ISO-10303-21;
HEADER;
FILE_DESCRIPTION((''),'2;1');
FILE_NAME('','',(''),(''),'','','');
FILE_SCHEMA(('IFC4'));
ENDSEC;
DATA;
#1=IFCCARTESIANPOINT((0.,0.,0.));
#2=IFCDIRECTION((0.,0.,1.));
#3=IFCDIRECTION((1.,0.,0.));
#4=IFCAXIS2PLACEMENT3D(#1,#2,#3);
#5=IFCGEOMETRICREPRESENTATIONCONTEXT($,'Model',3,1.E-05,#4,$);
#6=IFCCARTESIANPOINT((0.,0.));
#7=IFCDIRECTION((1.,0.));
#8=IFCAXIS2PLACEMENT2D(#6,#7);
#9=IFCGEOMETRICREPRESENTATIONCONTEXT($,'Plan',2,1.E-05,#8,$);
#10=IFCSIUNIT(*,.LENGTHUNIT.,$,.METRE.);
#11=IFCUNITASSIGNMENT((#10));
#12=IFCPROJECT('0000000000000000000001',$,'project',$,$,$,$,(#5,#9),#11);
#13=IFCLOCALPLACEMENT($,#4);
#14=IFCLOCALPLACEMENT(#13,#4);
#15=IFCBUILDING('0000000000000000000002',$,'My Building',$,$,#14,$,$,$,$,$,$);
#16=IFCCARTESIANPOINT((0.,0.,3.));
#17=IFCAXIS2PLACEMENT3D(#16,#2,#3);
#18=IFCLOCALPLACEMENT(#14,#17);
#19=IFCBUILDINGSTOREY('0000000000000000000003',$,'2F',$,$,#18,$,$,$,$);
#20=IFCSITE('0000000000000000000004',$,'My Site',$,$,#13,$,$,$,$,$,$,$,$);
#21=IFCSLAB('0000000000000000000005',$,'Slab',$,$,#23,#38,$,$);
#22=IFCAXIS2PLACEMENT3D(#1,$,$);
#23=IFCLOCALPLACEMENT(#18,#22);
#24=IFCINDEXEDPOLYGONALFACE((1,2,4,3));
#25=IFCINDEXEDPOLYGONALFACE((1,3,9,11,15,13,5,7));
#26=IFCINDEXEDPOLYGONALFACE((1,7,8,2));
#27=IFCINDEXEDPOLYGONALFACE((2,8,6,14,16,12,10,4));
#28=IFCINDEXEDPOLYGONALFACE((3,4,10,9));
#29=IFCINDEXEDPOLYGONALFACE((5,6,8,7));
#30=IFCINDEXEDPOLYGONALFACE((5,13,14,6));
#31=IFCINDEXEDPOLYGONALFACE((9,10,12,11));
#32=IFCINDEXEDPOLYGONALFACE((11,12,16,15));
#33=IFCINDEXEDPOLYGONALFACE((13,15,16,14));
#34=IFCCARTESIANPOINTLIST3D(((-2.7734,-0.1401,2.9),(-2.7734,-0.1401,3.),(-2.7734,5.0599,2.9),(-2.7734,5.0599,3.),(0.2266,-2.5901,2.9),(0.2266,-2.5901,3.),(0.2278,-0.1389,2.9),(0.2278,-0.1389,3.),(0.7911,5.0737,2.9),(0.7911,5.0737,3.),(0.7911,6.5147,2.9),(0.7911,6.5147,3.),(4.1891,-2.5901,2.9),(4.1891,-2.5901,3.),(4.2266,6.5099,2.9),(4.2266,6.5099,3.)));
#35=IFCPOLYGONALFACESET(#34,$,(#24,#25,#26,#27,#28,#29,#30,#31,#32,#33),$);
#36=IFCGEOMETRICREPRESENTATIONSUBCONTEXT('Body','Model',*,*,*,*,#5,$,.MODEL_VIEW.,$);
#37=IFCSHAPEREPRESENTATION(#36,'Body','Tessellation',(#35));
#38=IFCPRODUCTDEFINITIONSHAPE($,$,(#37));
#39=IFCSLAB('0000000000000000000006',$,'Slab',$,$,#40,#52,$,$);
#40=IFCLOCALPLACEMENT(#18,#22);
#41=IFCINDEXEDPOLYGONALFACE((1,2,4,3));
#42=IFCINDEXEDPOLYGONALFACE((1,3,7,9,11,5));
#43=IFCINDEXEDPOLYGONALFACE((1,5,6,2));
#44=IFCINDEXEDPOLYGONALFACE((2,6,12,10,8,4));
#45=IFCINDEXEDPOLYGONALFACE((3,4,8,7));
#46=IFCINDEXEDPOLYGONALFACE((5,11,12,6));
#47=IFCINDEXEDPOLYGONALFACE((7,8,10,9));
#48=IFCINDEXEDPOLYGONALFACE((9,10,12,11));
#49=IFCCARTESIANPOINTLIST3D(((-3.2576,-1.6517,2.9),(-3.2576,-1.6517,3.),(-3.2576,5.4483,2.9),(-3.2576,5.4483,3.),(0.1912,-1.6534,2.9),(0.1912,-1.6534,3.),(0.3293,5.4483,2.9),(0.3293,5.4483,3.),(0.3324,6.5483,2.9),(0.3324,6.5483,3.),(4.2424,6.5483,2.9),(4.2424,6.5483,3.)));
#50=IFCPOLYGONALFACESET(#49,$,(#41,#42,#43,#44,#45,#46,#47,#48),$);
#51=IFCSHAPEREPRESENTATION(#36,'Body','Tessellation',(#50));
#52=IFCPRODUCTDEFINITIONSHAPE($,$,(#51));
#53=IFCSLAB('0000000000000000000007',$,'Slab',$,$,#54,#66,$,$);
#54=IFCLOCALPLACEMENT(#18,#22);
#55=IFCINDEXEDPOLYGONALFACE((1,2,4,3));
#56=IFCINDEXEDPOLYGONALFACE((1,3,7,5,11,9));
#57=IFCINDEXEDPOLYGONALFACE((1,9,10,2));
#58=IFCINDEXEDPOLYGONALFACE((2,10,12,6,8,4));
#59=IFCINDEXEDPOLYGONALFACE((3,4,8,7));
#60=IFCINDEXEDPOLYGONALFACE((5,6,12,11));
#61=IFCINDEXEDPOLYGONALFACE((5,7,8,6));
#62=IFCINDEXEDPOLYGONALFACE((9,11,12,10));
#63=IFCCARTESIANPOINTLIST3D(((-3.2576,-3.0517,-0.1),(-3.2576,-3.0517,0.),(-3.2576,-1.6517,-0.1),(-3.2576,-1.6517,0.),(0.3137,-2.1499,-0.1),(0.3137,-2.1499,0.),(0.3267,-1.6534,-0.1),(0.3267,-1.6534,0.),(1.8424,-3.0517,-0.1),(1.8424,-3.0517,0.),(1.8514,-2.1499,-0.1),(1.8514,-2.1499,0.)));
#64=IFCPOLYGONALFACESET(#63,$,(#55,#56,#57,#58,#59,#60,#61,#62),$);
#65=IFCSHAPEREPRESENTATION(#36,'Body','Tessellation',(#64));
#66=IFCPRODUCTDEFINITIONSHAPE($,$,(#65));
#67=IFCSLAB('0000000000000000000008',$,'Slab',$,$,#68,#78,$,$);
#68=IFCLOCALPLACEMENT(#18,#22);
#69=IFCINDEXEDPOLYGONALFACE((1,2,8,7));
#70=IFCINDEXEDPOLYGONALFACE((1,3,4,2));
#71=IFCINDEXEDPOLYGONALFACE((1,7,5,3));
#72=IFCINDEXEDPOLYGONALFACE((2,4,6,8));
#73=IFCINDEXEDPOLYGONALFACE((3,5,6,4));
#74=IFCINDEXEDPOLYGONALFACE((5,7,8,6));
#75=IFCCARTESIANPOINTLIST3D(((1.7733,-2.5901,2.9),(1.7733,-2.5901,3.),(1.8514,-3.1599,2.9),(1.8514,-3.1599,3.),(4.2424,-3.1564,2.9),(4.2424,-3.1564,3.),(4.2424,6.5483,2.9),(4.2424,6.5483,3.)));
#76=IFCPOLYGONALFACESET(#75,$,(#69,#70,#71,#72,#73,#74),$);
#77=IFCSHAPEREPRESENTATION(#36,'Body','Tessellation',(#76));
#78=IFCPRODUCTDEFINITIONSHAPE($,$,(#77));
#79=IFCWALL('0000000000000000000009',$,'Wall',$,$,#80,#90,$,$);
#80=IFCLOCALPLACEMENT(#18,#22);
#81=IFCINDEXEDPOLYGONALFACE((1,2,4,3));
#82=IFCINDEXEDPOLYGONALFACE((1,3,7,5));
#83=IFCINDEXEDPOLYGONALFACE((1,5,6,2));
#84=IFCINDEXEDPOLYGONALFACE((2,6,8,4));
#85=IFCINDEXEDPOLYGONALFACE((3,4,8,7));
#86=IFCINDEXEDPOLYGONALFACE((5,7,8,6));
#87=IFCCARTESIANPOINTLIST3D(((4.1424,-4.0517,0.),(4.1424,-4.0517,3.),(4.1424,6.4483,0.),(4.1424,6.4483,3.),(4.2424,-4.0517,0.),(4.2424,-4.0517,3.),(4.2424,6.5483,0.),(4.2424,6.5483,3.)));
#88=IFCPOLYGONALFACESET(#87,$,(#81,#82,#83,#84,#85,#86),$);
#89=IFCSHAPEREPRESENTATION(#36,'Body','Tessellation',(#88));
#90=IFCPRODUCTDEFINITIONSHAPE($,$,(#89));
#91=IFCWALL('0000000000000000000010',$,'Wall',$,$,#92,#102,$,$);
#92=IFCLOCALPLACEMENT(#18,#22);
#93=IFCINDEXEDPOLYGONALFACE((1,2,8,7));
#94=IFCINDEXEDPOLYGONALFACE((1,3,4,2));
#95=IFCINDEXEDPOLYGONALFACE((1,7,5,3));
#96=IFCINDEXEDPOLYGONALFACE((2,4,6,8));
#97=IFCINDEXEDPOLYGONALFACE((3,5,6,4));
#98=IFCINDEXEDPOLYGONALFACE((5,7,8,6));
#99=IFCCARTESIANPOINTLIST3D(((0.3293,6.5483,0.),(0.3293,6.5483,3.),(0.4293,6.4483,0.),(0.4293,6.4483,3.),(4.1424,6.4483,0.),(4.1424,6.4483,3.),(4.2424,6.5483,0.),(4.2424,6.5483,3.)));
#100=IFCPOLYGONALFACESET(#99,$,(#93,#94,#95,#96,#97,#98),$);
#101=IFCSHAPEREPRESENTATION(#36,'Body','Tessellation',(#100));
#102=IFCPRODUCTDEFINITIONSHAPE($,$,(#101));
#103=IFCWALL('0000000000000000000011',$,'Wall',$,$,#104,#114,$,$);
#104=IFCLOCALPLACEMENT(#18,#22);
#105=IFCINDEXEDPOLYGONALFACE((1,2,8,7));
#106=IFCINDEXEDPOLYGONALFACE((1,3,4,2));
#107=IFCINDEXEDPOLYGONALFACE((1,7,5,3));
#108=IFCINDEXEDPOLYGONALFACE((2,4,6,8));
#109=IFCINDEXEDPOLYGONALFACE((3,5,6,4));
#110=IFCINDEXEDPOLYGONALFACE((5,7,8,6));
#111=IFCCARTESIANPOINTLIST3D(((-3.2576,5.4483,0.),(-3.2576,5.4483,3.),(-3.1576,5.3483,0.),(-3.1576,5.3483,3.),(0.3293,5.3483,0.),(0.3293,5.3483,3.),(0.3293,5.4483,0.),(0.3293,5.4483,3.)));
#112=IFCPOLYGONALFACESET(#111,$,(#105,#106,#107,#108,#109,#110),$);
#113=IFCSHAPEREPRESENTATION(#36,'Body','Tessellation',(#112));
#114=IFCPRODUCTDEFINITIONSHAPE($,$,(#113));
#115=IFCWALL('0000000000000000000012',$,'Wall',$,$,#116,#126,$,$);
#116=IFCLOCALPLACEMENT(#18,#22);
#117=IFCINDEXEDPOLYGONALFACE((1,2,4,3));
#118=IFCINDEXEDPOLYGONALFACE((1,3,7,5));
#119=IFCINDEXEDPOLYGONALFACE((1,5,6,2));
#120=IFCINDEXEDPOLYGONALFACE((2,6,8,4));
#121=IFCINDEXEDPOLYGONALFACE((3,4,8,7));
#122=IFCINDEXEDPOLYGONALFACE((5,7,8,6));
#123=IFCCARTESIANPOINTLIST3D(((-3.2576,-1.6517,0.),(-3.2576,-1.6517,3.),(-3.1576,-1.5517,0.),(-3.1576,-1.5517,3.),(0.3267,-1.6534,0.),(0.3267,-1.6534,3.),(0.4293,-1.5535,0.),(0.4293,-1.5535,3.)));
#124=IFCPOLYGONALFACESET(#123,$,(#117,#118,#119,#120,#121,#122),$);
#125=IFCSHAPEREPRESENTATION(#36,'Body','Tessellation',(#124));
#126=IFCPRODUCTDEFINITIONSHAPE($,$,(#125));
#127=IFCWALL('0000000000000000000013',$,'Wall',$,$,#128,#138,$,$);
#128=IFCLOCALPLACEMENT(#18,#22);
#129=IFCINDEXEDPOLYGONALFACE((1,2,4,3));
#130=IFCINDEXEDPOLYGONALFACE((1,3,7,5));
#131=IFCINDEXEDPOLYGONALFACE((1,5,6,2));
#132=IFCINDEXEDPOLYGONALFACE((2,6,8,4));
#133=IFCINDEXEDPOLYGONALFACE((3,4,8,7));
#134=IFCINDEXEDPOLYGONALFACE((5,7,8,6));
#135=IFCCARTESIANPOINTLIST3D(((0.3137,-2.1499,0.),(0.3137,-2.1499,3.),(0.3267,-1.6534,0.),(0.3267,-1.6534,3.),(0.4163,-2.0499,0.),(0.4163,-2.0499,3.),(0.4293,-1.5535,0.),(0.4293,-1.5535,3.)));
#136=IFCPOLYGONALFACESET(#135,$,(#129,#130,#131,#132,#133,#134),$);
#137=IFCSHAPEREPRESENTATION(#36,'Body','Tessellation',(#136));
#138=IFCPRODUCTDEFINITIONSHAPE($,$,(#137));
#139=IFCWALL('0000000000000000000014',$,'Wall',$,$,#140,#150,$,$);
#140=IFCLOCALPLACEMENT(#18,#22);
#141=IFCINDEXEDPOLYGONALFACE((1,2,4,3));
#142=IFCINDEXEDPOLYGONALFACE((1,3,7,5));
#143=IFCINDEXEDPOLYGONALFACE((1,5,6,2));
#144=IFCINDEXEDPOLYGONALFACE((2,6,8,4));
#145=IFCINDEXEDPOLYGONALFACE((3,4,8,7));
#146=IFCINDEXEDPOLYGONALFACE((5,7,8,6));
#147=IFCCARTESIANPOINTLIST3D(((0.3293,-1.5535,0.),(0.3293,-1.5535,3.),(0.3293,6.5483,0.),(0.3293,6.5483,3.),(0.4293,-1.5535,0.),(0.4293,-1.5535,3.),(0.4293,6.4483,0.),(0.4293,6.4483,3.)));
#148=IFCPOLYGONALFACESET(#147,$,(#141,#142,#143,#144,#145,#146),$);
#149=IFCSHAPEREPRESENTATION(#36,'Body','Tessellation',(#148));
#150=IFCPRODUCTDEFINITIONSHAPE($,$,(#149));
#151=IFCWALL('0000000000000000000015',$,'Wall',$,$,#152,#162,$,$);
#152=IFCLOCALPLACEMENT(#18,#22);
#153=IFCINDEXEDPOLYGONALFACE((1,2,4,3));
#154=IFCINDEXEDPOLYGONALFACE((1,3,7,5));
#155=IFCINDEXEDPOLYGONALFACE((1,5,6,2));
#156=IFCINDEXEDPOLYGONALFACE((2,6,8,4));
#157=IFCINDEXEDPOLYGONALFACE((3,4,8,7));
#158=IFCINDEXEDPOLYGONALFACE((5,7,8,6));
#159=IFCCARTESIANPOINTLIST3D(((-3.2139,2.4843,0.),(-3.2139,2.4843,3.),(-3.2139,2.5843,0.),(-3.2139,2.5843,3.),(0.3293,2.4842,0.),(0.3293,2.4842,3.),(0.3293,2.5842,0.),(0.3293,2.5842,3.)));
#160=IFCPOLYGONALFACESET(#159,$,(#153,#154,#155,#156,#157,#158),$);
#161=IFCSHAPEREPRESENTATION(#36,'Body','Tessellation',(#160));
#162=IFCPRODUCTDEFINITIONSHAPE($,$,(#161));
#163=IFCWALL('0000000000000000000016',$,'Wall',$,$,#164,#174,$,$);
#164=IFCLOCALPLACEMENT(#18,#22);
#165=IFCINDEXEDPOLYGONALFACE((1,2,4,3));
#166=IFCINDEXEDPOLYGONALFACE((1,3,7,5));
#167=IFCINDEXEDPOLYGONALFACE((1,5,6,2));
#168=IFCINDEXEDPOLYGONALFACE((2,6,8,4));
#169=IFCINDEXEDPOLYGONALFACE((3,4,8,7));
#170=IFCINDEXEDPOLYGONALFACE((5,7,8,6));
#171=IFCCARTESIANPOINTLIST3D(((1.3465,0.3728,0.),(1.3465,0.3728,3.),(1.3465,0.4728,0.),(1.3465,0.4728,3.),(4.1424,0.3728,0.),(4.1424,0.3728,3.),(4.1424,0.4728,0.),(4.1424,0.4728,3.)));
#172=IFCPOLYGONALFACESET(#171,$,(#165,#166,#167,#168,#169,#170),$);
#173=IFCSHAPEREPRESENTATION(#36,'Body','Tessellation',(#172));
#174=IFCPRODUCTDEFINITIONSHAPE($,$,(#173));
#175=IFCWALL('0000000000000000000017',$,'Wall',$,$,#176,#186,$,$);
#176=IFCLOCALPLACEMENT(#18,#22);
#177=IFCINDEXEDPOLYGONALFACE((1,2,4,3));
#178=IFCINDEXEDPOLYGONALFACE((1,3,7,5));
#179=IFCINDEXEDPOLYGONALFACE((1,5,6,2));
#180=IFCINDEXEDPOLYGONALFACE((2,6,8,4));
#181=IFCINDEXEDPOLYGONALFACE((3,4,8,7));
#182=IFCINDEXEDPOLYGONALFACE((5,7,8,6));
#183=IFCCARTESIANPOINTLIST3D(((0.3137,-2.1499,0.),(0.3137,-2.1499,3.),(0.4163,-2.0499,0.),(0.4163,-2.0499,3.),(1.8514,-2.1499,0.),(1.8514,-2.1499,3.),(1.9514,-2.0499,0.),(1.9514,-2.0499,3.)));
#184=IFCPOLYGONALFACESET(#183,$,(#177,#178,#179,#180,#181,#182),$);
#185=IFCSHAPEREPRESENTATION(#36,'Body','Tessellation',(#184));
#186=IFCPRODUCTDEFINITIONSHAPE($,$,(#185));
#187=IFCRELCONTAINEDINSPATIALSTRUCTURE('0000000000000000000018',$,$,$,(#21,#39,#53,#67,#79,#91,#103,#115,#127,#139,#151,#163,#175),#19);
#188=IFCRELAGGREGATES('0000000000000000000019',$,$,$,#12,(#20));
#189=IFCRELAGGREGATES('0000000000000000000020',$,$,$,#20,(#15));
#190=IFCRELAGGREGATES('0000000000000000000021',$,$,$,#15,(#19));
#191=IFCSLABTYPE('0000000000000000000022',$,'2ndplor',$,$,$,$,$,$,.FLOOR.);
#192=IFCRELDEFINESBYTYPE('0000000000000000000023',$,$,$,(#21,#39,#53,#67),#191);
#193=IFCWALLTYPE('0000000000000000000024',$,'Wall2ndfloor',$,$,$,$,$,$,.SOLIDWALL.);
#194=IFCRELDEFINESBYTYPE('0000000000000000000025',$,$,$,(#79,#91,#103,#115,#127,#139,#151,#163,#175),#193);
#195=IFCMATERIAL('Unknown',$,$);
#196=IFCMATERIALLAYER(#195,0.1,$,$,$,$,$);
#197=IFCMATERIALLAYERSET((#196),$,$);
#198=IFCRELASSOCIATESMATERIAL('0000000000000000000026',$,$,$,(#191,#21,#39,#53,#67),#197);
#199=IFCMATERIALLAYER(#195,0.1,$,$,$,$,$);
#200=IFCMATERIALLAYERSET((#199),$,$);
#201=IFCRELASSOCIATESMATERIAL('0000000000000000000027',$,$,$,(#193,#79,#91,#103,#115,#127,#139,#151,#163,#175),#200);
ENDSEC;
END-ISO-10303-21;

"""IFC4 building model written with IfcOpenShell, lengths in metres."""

from ifc_helpers import new_model, si_unit, frame, origin_with_axes, origin_2d_with_axis, place, context, subcontext, project, spatial, line, indexed_curve, outline, extrude, material, layer, layer_set, layer_usage, type_object, element, save


model = new_model("IFC4")

# Units and contexts
model_context = context("Model", 3, precision=1e-05, world=origin_with_axes())
plan_context = context("Plan", 2, precision=1e-05, world=origin_2d_with_axis())
body_context_1 = subcontext(model_context, "Body", "Model", "MODEL_VIEW")
ifc_project = project(units=[si_unit("LENGTHUNIT", "METRE")], contexts=[model_context, plan_context])

# Site, building, storey
site_placement = place(None, origin_with_axes())
site = spatial("IfcSite", under=ifc_project, at=site_placement, Name="My Site")
building_placement = place(site_placement, origin_with_axes())
building = spatial("IfcBuilding", under=site, at=building_placement, Name="My Building")
storey_placement = place(building_placement, frame((0.0, 0.0, 3.0), z_axis=(0.0, 0.0, 1.0), x_axis=(1.0, 0.0, 0.0)))
storey = spatial("IfcBuildingStorey", under=building, at=storey_placement, Name="2F")

# Slabs
ifc_material = material(Name="Unknown")
ifc_layer_1 = layer(ifc_material, 0.1)
ifc_layer_set_1 = layer_set([ifc_layer_1])
ifc_layer_usage_1 = layer_usage(ifc_layer_set_1, "AXIS3", "POSITIVE", -0.1)
slab_type = type_object("IfcSlabType", Name="2ndplor", PredefinedType="FLOOR", material=ifc_layer_set_1)
slab_1_placement = place(storey_placement, frame((4.1891, -2.5901, 3.0), z_axis=(0.0, 0.0, 1.0), x_axis=(1.0, 0.0, 0.0)))
element("IfcSlab", 1, at=slab_1_placement, inside=storey, type_object=slab_type, material=ifc_layer_usage_1, Name="Slab", context=body_context_1, shape_type="SweptSolid", body=[
    extrude(outline(indexed_curve([(0.0, 0.0), (0.0375, 9.1), (-3.398, 9.1048), (-3.398, 7.6638), (-6.9625, 7.65), (-6.9625, 2.45), (-3.9613, 2.4512), (-3.9625, 0.0), (0.0, 0.0)])), frame((0.0, 0.0, -0.1), z_axis=(0.0, 0.0, 1.0), x_axis=(1.0, 0.0, 0.0)), (0.0, 0.0, 1.0), 0.1),
])
ifc_layer_usage_2 = layer_usage(ifc_layer_set_1, "AXIS3", "POSITIVE", -0.1)
slab_2_placement = place(storey_placement, frame((4.2424, 6.5483, 3.0), z_axis=(0.0, 0.0, 1.0), x_axis=(1.0, 0.0, 0.0)))
element("IfcSlab", 2, at=slab_2_placement, inside=storey, type_object=slab_type, material=ifc_layer_usage_2, Name="Slab", context=body_context_1, shape_type="SweptSolid", body=[
    extrude(outline(indexed_curve([(0.0, 0.0), (-3.91, 0.0), (-3.9131, -1.1), (-7.5, -1.1), (-7.5, -8.2), (-4.0512, -8.2017), (0.0, 0.0)])), frame((0.0, 0.0, -0.1), z_axis=(0.0, 0.0, 1.0), x_axis=(1.0, 0.0, 0.0)), (0.0, 0.0, 1.0), 0.1),
])
ifc_layer_usage_3 = layer_usage(ifc_layer_set_1, "AXIS3", "POSITIVE", -0.1)
slab_3_placement = place(storey_placement, frame((-3.2576, -1.6517, 0.0), z_axis=(0.0, 0.0, 1.0), x_axis=(1.0, 0.0, 0.0)))
element("IfcSlab", 3, at=slab_3_placement, inside=storey, type_object=slab_type, material=ifc_layer_usage_3, Name="Slab", context=body_context_1, shape_type="SweptSolid", body=[
    extrude(outline(indexed_curve([(0.0, 0.0), (0.0, -1.4), (5.1, -1.4), (5.109, -0.4982), (3.5713, -0.4982), (3.5843, -0.0017), (0.0, 0.0)])), frame((0.0, 0.0, -0.1), z_axis=(0.0, 0.0, 1.0), x_axis=(1.0, 0.0, 0.0)), (0.0, 0.0, 1.0), 0.1),
])
ifc_layer_usage_4 = layer_usage(ifc_layer_set_1, "AXIS3", "POSITIVE", -0.1)
slab_4_placement = place(storey_placement, frame((1.7733, -2.5901, 3.0), z_axis=(0.0, 0.0, 1.0), x_axis=(1.0, 0.0, 0.0)))
element("IfcSlab", 4, at=slab_4_placement, inside=storey, type_object=slab_type, material=ifc_layer_usage_4, Name="Slab", context=body_context_1, shape_type="SweptSolid", body=[
    extrude(outline(indexed_curve([(0.0, 0.0), (0.078, -0.5697), (2.4691, -0.5663), (2.4691, 9.1384), (0.0, 0.0)])), frame((0.0, 0.0, -0.1), z_axis=(0.0, 0.0, 1.0), x_axis=(1.0, 0.0, 0.0)), (0.0, 0.0, 1.0), 0.1),
])

# Walls
ifc_layer_2 = layer(ifc_material, 0.1)
ifc_layer_set_2 = layer_set([ifc_layer_2])
ifc_layer_usage_5 = layer_usage(ifc_layer_set_2, "AXIS2", "POSITIVE", 0.0)
wall_type = type_object("IfcWallType", Name="Wall2ndfloor", PredefinedType="SOLIDWALL", material=ifc_layer_set_2)
wall_1_placement = place(storey_placement, frame((4.2424, -4.0517, 0.0), z_axis=(0.0, 0.0, 1.0), x_axis=(0.0, 1.0, 0.0)))
element("IfcWall", 5, at=wall_1_placement, inside=storey, type_object=wall_type, material=ifc_layer_usage_5, Name="Wall", context=body_context_1, shape_type="SweptSolid", body=[
    extrude(outline(indexed_curve([(0.0, 0.0), (0.0, 0.1), (10.5, 0.1), (10.6, 0.0)], segments=[line(1, 2, 3, 4, 1)])), origin_with_axes(), (0.0, 0.0, 1.0), 3.0),
])
ifc_layer_usage_6 = layer_usage(ifc_layer_set_2, "AXIS2", "POSITIVE", 0.0)
wall_2_placement = place(storey_placement, frame((4.2424, 6.5483, 0.0), z_axis=(0.0, 0.0, 1.0), x_axis=(-1.0, 0.0, 0.0)))
element("IfcWall", 6, at=wall_2_placement, inside=storey, type_object=wall_type, material=ifc_layer_usage_6, Name="Wall", context=body_context_1, shape_type="SweptSolid", body=[
    extrude(outline(indexed_curve([(0.0, 0.0), (0.1, 0.1), (3.8131, 0.1), (3.9131, 0.0)], segments=[line(1, 2, 3, 4, 1)])), origin_with_axes(), (0.0, 0.0, 1.0), 3.0),
])
ifc_layer_usage_7 = layer_usage(ifc_layer_set_2, "AXIS2", "POSITIVE", 0.0)
wall_3_placement = place(storey_placement, frame((0.4293, 5.4483, 0.0), z_axis=(0.0, 0.0, 1.0), x_axis=(-1.0, 0.0, 0.0)))
element("IfcWall", 7, at=wall_3_placement, inside=storey, type_object=wall_type, material=ifc_layer_usage_7, Name="Wall", context=body_context_1, shape_type="SweptSolid", body=[
    extrude(outline(indexed_curve([(0.1, 0.0), (0.1, 0.1), (3.5869, 0.1), (3.6869, 0.0)], segments=[line(1, 2, 3, 4, 1)])), origin_with_axes(), (0.0, 0.0, 1.0), 3.0),
])

# Walls
ifc_layer_usage_8 = layer_usage(ifc_layer_set_2, "AXIS2", "POSITIVE", 0.0)
wall_4_placement = place(storey_placement, frame((-3.2576, -1.6517, 0.0), z_axis=(0.0, 0.0, 1.0), x_axis=(1.0, -0.000484, 0.0)))
element("IfcWall", 8, at=wall_4_placement, inside=storey, type_object=wall_type, material=ifc_layer_usage_8, Name="Wall", context=body_context_1, shape_type="SweptSolid", body=[
    extrude(outline(indexed_curve([(0.0, 0.0), (0.1, 0.1), (3.6869, 0.1), (3.5843, 0.0)], segments=[line(1, 2, 3, 4, 1)])), origin_with_axes(), (0.0, 0.0, 1.0), 3.0),
])
ifc_layer_usage_9 = layer_usage(ifc_layer_set_2, "AXIS2", "POSITIVE", 0.0)
wall_5_placement = place(storey_placement, frame((0.3267, -1.6534, 0.0), z_axis=(0.0, 0.0, 1.0), x_axis=(-0.026114, -0.999659, 0.0)))
element("IfcWall", 9, at=wall_5_placement, inside=storey, type_object=wall_type, material=ifc_layer_usage_9, Name="Wall", context=body_context_1, shape_type="SweptSolid", body=[
    extrude(outline(indexed_curve([(0.0, 0.0), (-0.1026, 0.1), (0.3939, 0.1), (0.4966, 0.0)], segments=[line(1, 2, 3, 4, 1)])), origin_with_axes(), (0.0, 0.0, 1.0), 3.0),
])
ifc_layer_usage_10 = layer_usage(ifc_layer_set_2, "AXIS2", "POSITIVE", 0.0)
wall_6_placement = place(storey_placement, frame((0.4293, -1.5535, 0.0), z_axis=(0.0, 0.0, 1.0), x_axis=(0.0, 1.0, 0.0)))
element("IfcWall", 10, at=wall_6_placement, inside=storey, type_object=wall_type, material=ifc_layer_usage_10, Name="Wall", context=body_context_1, shape_type="SweptSolid", body=[
    extrude(outline(indexed_curve([(0.0, 0.0), (0.0, 0.1), (8.1018, 0.1), (8.0018, 0.0)], segments=[line(1, 2, 3, 4, 1)])), origin_with_axes(), (0.0, 0.0, 1.0), 3.0),
])
ifc_layer_usage_11 = layer_usage(ifc_layer_set_2, "AXIS2", "POSITIVE", 0.0)
wall_7_placement = place(storey_placement, frame((-3.2139, 2.4843, 0.0), z_axis=(0.0, 0.0, 1.0), x_axis=(1.0, -0.000006, 0.0)))
element("IfcWall", 11, at=wall_7_placement, inside=storey, type_object=wall_type, material=ifc_layer_usage_11, Name="Wall", context=body_context_1, shape_type="SweptSolid", body=[
    extrude(outline(indexed_curve([(0.0, 0.0), (0.0, 0.1), (3.5432, 0.1), (3.5432, 0.0)], segments=[line(1, 2, 3, 4, 1)])), origin_with_axes(), (0.0, 0.0, 1.0), 3.0),
])
ifc_layer_usage_12 = layer_usage(ifc_layer_set_2, "AXIS2", "POSITIVE", 0.0)
wall_8_placement = place(storey_placement, frame((1.3465, 0.3728, 0.0), z_axis=(0.0, 0.0, 1.0), x_axis=(1.0, 0.0, 0.0)))
element("IfcWall", 12, at=wall_8_placement, inside=storey, type_object=wall_type, material=ifc_layer_usage_12, Name="Wall", context=body_context_1, shape_type="SweptSolid", body=[
    extrude(outline(indexed_curve([(0.0, 0.0), (0.0, 0.1), (2.7959, 0.1), (2.7959, 0.0)], segments=[line(1, 2, 3, 4, 1)])), origin_with_axes(), (0.0, 0.0, 1.0), 3.0),
])
ifc_layer_usage_13 = layer_usage(ifc_layer_set_2, "AXIS2", "POSITIVE", 0.0)
wall_9_placement = place(storey_placement, frame((1.8514, -2.0499, 0.0), z_axis=(0.0, 0.0, 1.0), x_axis=(-1.0, 0.0, 0.0)))
element("IfcWall", 13, at=wall_9_placement, inside=storey, type_object=wall_type, material=ifc_layer_usage_13, Name="Wall", context=body_context_1, shape_type="SweptSolid", body=[
    extrude(outline(indexed_curve([(-0.1, 0.0), (0.0, 0.1), (1.5377, 0.1), (1.435, 0.0)], segments=[line(1, 2, 3, 4, 1)])), origin_with_axes(), (0.0, 0.0, 1.0), 3.0),
])

save(model, "model.ifc")
